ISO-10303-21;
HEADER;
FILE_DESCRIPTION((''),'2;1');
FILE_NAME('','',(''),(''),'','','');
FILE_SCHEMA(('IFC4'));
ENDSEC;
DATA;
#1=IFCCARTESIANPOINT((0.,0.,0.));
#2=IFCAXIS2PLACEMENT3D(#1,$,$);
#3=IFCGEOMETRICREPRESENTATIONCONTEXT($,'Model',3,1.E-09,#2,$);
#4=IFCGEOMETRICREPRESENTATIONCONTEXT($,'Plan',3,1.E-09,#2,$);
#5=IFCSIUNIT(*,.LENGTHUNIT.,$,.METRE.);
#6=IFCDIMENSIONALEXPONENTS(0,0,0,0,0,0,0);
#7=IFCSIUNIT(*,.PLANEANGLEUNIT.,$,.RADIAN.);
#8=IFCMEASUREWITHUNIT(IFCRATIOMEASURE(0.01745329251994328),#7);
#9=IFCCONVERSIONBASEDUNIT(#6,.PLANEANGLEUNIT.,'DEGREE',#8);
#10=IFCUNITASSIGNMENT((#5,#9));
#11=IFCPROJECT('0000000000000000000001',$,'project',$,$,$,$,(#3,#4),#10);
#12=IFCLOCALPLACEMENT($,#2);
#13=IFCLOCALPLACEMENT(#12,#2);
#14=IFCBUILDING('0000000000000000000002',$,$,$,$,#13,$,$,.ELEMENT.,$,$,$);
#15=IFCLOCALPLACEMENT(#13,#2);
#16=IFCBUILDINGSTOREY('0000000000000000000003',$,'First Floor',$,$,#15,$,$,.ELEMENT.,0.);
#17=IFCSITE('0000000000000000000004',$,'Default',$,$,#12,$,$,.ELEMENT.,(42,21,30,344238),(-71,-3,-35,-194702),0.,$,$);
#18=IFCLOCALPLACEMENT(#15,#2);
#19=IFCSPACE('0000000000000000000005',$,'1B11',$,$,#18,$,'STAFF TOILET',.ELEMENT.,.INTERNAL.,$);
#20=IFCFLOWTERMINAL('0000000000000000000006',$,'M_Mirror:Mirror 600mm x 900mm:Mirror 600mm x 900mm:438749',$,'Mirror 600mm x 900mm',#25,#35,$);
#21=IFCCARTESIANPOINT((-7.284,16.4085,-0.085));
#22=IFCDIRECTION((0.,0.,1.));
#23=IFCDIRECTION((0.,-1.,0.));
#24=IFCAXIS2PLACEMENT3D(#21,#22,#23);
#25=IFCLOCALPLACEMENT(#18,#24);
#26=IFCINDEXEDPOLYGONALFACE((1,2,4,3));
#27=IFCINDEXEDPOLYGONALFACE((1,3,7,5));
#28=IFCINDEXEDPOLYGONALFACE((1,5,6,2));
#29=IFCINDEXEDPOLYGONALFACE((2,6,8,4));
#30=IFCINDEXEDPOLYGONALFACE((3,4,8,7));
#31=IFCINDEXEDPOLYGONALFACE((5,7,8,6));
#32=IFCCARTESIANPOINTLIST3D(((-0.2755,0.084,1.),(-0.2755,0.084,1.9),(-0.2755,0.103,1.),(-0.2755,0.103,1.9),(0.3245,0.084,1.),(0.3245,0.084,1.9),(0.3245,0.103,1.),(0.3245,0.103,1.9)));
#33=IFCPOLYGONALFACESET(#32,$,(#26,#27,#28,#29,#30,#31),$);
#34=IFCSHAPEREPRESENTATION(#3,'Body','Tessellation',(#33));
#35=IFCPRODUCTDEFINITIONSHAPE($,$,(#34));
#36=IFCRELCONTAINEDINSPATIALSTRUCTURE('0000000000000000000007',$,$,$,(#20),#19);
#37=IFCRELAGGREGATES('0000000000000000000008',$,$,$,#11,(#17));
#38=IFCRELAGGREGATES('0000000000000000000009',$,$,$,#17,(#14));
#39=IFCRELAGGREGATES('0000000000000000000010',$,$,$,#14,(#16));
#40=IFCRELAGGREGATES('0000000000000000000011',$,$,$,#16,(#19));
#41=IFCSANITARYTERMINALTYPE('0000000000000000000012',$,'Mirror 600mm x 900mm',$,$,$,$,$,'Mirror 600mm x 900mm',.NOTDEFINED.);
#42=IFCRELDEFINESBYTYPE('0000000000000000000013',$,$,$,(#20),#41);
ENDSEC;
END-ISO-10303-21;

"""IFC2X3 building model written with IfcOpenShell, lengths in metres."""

from ifc_helpers import new_model, entity, si_unit, converted_unit, frame, origin, origin_2d_with_axis, place, context, project, spatial, rectangle, extrude, source, transform, mapped, type_object, type_shapes, element, save


model = new_model("IFC2X3")

# Units and contexts
model_context = context("Model", 3, precision=1e-09, world=origin())
plan_context = context("Plan", 3, precision=1e-09, world=origin())
ifc_project = project(units=[si_unit("LENGTHUNIT", "METRE"), converted_unit("PLANEANGLEUNIT", "DEGREE", entity("IfcRatioMeasure", 0.01745329251994328), si_unit("PLANEANGLEUNIT", "RADIAN"), dimensions=[0, 0, 0, 0, 0, 0, 0])], contexts=[model_context, plan_context])

# Site, building, storey
site_placement = place(None, origin())
site = spatial("IfcSite", under=ifc_project, at=site_placement, Name="Default", CompositionType="ELEMENT", RefLatitude=(42, 21, 30, 344238), RefLongitude=(-71, -3, -35, -194702), RefElevation=0.0)
building_placement = place(site_placement, origin())
building = spatial("IfcBuilding", under=site, at=building_placement, CompositionType="ELEMENT")
storey_placement = place(building_placement, origin())
storey = spatial("IfcBuildingStorey", under=building, at=storey_placement, Name="First Floor", CompositionType="ELEMENT", Elevation=0.0)

# Shared definitions
space_1_placement = place(storey_placement, origin())
space_1 = spatial("IfcSpace", under=storey, at=space_1_placement, Name="1B11", LongName="STAFF TOILET", CompositionType="ELEMENT", InteriorOrExteriorSpace="INTERNAL")

# Flow terminal
sanitary_terminal_type_1 = type_object("IfcSanitaryTerminalType", Name="Mirror 600mm x 900mm", ElementType="Mirror 600mm x 900mm", PredefinedType="NOTDEFINED")
shared_shape_1 = source(origin(), model_context, "Body", "SweptSolid", [
    extrude(rectangle(XDim=0.0191, YDim=0.6, at=origin_2d_with_axis()), frame((0.0245, 0.0935, 1.0), z_axis=(0.0, 0.0, 1.0), x_axis=(0.0, -1.0, 0.0)), (0.0, 0.0, 1.0), 0.9),
])
type_shapes(sanitary_terminal_type_1, [shared_shape_1])
flow_terminal_1_placement = place(space_1_placement, frame((-7.284, 16.4085, -0.085), z_axis=(0.0, 0.0, 1.0), x_axis=(0.0, -1.0, 0.0)))
element("IfcFlowTerminal", 1, at=flow_terminal_1_placement, inside=space_1, type_object=sanitary_terminal_type_1, Name="M_Mirror:Mirror 600mm x 900mm:Mirror 600mm x 900mm:438749", ObjectType="Mirror 600mm x 900mm", context=model_context, shape_type="MappedRepresentation", body=[
    mapped(shared_shape_1, transform((0.0, 0.0, 0.0), scale=1.0)),
])

save(model, "model.ifc")
